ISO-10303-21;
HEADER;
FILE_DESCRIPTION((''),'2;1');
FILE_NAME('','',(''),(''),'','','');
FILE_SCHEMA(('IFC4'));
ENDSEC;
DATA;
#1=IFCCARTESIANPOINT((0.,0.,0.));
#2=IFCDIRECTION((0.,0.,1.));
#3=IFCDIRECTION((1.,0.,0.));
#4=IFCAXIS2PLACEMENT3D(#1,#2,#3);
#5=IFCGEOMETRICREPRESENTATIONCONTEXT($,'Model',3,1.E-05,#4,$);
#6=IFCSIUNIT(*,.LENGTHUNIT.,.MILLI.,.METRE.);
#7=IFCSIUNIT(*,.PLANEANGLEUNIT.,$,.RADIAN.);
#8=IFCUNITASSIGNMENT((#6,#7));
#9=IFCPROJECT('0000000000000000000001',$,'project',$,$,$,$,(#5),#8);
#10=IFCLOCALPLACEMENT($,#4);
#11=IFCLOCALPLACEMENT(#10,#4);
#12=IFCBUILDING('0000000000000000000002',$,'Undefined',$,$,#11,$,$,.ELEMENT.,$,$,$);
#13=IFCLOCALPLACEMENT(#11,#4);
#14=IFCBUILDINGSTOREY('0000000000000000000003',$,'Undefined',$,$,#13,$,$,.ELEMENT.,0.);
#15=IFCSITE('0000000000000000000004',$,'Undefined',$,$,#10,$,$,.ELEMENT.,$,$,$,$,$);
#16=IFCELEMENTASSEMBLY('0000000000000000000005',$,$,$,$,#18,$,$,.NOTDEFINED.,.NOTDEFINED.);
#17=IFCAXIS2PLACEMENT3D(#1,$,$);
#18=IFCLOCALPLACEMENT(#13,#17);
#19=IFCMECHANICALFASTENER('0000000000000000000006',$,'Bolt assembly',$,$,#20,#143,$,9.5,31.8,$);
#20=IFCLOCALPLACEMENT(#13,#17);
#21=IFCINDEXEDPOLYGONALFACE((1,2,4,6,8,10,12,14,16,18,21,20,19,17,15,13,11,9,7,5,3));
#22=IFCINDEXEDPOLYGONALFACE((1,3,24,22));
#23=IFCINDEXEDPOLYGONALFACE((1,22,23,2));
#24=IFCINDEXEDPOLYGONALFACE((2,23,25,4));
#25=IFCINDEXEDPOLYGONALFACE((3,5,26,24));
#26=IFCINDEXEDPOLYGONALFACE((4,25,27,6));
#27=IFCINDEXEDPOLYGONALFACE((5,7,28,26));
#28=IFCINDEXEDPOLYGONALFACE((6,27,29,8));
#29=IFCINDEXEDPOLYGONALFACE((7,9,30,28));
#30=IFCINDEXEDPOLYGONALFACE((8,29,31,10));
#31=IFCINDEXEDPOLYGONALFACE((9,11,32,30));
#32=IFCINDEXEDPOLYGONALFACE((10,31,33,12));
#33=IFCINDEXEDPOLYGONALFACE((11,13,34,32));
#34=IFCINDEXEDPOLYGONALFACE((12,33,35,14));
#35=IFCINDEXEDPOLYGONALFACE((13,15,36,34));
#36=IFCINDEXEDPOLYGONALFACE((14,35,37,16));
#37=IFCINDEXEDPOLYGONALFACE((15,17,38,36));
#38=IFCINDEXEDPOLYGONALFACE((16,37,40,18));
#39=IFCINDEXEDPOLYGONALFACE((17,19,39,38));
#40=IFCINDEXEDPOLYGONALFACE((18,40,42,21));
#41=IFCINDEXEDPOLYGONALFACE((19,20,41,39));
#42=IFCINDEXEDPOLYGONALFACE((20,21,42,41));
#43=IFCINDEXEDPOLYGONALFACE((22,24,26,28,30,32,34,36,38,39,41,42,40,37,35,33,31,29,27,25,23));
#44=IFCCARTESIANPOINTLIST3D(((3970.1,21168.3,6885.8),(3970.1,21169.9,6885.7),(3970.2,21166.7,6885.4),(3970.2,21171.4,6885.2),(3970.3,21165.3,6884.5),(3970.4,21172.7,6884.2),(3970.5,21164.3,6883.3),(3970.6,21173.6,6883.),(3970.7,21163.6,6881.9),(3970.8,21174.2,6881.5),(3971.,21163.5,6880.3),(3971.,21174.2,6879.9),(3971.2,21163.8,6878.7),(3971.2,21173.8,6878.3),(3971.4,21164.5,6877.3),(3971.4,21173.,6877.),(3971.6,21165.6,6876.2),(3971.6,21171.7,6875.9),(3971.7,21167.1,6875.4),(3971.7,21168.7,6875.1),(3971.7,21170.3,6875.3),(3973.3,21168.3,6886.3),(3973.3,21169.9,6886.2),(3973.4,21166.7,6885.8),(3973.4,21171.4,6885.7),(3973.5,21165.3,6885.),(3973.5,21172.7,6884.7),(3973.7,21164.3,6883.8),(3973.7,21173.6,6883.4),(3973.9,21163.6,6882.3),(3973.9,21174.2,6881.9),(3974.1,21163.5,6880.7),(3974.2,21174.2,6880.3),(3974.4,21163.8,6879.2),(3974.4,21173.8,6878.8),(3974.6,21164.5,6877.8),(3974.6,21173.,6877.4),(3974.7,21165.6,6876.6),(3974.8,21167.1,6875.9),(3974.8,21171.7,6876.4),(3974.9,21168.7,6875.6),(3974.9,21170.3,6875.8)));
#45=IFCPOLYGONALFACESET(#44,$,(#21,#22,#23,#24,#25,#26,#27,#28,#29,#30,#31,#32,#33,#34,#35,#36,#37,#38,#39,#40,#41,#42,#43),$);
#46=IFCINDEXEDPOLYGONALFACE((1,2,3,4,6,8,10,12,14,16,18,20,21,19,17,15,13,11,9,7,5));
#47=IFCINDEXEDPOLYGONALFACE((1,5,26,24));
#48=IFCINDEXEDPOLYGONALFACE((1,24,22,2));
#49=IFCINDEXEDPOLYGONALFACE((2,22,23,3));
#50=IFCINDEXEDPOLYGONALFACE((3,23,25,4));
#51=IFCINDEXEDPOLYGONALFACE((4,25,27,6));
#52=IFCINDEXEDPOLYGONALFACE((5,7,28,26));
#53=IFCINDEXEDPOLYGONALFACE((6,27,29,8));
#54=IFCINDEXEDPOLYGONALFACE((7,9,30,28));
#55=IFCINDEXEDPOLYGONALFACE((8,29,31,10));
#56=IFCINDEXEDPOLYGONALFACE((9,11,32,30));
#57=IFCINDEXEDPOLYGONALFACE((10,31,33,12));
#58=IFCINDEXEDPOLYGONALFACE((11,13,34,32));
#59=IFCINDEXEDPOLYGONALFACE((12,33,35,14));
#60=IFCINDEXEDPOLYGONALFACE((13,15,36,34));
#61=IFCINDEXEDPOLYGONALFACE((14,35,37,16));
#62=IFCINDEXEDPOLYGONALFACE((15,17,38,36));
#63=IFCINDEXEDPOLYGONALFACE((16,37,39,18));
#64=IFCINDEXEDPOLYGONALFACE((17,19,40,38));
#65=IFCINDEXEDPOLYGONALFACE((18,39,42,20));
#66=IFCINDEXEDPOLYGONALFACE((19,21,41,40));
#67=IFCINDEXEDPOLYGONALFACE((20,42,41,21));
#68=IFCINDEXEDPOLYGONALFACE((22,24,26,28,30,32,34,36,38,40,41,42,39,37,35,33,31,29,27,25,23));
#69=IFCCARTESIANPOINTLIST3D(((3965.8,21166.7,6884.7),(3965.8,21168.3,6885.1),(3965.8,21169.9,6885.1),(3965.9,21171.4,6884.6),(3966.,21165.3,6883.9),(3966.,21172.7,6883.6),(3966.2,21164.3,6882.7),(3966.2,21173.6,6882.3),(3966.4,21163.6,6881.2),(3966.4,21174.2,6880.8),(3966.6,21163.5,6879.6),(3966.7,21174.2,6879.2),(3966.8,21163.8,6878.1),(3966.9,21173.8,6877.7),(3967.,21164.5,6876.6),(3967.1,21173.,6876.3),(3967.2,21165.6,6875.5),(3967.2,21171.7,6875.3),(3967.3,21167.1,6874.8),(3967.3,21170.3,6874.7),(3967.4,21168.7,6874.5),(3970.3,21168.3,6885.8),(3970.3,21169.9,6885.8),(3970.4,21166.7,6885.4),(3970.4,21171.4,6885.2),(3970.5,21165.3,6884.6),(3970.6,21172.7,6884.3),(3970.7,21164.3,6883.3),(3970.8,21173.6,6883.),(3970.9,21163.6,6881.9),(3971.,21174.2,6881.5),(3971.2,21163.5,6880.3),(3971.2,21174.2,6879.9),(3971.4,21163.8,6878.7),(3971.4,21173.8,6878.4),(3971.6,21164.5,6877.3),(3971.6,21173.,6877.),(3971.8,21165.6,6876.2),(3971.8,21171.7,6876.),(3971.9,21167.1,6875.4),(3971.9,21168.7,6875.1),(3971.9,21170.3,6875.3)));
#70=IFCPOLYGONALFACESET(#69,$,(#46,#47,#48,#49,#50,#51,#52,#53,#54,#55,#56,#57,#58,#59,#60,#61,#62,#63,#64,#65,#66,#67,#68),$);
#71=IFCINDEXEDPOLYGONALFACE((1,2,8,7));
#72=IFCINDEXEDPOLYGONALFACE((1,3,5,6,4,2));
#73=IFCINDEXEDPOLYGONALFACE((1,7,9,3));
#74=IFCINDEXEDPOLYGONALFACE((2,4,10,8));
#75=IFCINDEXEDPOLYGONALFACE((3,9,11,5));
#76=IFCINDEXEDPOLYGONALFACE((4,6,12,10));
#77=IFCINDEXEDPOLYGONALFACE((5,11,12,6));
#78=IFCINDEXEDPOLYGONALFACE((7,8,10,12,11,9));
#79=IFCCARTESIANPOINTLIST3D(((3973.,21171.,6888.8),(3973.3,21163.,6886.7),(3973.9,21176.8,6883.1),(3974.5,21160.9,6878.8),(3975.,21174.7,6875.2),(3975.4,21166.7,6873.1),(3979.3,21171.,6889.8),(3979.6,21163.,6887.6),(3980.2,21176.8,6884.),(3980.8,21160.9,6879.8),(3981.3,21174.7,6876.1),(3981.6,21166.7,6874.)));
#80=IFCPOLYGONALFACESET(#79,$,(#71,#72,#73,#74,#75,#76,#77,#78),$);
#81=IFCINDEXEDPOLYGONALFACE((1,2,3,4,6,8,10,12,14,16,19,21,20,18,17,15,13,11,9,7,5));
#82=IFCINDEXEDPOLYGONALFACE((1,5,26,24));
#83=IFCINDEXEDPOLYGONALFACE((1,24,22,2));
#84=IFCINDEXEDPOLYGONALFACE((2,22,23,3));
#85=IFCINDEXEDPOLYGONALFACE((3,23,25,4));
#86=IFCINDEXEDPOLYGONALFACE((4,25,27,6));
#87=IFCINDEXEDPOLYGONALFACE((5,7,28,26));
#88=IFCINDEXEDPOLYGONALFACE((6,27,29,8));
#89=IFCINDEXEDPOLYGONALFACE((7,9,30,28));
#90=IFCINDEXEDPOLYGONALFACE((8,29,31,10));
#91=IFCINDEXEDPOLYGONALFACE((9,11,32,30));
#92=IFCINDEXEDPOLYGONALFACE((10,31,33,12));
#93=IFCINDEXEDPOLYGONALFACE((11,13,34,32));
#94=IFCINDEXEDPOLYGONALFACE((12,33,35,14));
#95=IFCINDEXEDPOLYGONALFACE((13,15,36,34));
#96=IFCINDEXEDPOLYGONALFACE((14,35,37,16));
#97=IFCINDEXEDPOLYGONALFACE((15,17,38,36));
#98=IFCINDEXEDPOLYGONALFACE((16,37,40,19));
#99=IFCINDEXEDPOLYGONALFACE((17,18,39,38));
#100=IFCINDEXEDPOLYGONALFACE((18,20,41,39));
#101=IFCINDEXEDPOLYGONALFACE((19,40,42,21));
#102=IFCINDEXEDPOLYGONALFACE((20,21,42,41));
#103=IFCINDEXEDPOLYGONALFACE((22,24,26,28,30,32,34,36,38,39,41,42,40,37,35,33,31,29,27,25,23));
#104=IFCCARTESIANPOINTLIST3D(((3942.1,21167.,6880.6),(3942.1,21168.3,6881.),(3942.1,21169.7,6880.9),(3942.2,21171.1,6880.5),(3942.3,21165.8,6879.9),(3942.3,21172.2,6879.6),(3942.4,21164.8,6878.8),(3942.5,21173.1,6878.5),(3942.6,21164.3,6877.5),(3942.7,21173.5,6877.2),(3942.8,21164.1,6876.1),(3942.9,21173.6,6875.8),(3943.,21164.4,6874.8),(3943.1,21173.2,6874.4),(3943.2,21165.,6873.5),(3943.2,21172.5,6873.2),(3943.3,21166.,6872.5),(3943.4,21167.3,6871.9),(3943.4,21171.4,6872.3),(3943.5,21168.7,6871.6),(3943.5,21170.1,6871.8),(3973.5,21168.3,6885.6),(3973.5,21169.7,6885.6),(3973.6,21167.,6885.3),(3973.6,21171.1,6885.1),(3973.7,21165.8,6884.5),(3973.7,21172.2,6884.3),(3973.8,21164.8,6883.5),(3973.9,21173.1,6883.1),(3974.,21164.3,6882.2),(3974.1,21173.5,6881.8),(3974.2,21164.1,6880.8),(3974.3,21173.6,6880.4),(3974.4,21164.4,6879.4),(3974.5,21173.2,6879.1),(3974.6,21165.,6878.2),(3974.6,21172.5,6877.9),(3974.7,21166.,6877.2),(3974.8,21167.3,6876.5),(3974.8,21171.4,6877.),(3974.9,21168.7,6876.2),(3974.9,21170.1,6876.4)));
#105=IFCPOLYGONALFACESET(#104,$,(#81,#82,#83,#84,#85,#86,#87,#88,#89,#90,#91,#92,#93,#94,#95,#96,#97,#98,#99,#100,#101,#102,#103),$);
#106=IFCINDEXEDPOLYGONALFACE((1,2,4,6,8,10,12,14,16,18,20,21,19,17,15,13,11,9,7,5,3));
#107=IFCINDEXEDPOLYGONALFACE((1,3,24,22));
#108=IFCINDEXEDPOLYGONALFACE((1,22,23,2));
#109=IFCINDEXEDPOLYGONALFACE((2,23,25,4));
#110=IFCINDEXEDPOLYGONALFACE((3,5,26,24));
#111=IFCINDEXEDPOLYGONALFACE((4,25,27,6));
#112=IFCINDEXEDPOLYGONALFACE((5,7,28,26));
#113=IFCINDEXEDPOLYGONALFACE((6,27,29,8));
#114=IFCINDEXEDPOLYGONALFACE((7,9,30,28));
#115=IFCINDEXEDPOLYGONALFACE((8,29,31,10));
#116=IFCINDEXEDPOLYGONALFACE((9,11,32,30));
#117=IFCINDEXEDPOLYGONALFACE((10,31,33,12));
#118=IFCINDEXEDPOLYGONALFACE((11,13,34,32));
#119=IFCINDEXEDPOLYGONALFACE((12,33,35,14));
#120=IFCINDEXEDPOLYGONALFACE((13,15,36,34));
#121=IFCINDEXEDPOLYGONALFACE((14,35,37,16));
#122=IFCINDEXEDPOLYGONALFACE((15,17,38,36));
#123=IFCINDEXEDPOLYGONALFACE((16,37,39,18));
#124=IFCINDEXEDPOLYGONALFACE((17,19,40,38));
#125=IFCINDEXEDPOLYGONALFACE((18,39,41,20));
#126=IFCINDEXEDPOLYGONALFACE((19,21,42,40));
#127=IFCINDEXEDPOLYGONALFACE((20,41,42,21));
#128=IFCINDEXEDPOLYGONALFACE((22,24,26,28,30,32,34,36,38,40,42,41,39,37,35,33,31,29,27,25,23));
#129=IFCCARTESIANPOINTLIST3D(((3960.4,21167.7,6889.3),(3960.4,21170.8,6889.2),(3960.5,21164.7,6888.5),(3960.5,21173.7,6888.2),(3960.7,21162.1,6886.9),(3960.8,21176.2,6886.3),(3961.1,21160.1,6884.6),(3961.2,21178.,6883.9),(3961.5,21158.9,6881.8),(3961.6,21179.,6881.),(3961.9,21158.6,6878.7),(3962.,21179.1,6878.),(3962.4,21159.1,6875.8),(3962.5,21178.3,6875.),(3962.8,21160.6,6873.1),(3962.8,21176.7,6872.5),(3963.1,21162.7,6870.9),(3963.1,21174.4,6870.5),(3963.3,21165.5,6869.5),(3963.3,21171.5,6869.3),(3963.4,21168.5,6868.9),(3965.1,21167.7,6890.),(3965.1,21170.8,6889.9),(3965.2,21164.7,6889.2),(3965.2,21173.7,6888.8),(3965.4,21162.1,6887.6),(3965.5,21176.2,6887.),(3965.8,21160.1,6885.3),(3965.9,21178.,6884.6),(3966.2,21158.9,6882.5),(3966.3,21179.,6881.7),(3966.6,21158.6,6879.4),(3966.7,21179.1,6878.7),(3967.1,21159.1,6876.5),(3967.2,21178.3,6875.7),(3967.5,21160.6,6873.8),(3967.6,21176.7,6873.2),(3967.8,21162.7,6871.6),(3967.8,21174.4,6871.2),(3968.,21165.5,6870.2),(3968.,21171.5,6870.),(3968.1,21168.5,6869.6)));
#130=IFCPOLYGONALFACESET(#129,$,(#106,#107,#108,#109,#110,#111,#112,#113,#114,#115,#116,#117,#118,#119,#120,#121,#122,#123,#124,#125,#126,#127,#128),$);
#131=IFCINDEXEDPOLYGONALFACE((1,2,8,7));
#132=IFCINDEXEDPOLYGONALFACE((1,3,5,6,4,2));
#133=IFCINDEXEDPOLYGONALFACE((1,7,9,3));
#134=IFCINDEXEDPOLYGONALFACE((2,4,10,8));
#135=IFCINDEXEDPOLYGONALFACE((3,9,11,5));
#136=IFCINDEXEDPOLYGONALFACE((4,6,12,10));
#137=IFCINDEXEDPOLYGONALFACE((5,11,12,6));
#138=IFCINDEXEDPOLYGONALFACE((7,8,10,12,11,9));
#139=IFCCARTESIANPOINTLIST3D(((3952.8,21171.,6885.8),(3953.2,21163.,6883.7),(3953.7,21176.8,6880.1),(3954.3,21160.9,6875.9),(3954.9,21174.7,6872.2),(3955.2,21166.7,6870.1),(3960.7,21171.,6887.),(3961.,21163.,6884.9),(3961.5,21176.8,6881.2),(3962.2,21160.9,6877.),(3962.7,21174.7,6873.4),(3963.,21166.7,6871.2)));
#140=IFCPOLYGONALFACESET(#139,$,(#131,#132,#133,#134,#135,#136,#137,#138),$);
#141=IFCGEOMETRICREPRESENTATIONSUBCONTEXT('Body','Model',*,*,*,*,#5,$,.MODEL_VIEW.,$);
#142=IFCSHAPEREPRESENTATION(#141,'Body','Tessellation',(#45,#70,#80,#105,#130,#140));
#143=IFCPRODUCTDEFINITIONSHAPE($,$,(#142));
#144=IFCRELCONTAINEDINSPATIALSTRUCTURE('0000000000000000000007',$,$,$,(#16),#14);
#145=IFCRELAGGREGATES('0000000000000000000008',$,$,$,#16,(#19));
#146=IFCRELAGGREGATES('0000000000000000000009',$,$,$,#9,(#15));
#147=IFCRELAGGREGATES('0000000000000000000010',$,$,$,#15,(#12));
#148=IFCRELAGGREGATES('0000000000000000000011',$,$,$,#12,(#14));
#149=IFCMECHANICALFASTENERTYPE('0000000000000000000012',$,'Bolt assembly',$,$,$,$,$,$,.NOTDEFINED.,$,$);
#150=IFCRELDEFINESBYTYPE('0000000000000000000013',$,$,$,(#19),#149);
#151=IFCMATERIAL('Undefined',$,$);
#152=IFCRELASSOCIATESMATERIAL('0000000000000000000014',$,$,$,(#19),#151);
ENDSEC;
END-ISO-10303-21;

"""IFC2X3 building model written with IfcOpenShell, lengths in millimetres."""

from ifc_helpers import new_model, si_unit, frame, origin_with_axes, origin_2d_with_axis, place, context, subcontext, project, spatial, polyline, circle, outline, extrude, source, transform, mapped, material, type_object, element, aggregate, save


model = new_model("IFC2X3")

# Units and contexts
model_context = context("Model", 3, precision=1e-05, world=origin_with_axes())
body_context = subcontext(model_context, "Body", "Model", "MODEL_VIEW")
ifc_project = project(units=[si_unit("LENGTHUNIT", "METRE", prefix="MILLI"), si_unit("PLANEANGLEUNIT", "RADIAN")], contexts=[model_context])

# Site, building, storey
site_placement = place(None, origin_with_axes())
site = spatial("IfcSite", under=ifc_project, at=site_placement, Name="Undefined", CompositionType="ELEMENT")
building_placement = place(site_placement, origin_with_axes())
building = spatial("IfcBuilding", under=site, at=building_placement, Name="Undefined", CompositionType="ELEMENT")
storey_placement = place(building_placement, origin_with_axes())
storey = spatial("IfcBuildingStorey", under=building, at=storey_placement, Name="Undefined", CompositionType="ELEMENT", Elevation=0.0)

# Element assembly
assembly_1_placement = place(storey_placement, origin_with_axes())
assembly_1 = element("IfcElementAssembly", 1, at=assembly_1_placement, inside=storey, AssemblyPlace="NOTDEFINED", PredefinedType="NOTDEFINED")

# Shared definitions
ifc_material_1 = material(Name="Undefined")
mechanical_fastener_type = type_object("IfcMechanicalFastenerType", Name="Bolt assembly")

# Mechanical fastener
shared_shape_1 = source(origin_with_axes(), body_context, "Body", "SweptSolid", [
    extrude(circle(Radius=5.4, at=origin_2d_with_axis()), frame((0.0, -3.1, 0.0), z_axis=(0.0, 1.0, 0.0), x_axis=(1.0, 0.0, 0.0)), (0.0, 0.0, 1.0), 3.2),
    extrude(circle(Radius=5.4, at=origin_2d_with_axis()), frame((0.0, -0.1, 0.0), z_axis=(0.0, 1.0, 0.0), x_axis=(1.0, 0.0, 0.0)), (0.0, 0.0, 1.0), 4.6),
    extrude(outline(polyline([(7.1, -4.1), (7.1, 4.1), (0.0, 8.2), (-7.1, 4.1), (-7.1, -4.1), (0.0, -8.2), (7.1, -4.1)])), frame((0.0, -9.6, 0.0), z_axis=(0.0, 1.0, 0.0), x_axis=(1.0, 0.0, 0.0)), (0.0, 0.0, 1.0), 6.3),
    extrude(circle(Radius=4.8, at=origin_2d_with_axis()), frame((0.0, -3.2, 0.0), z_axis=(0.0, 1.0, 0.0), x_axis=(1.0, 0.0, 0.0)), (0.0, 0.0, 1.0), 31.8),
    extrude(circle(Radius=10.3, at=origin_2d_with_axis()), frame((0.0, 4.5, 0.0), z_axis=(0.0, 1.0, 0.0), x_axis=(1.0, 0.0, 0.0)), (0.0, 0.0, 1.0), 4.8),
    extrude(outline(polyline([(7.1, -4.1), (7.1, 4.1), (0.0, 8.2), (-7.1, 4.1), (-7.1, -4.1), (0.0, -8.2), (7.1, -4.1)])), frame((0.0, 9.3, 0.0), z_axis=(0.0, 1.0, 0.0), x_axis=(1.0, 0.0, 0.0)), (0.0, 0.0, 1.0), 7.9),
])
mechanical_fastener_1_placement = place(assembly_1_placement, frame((3971.0, 21168.9, 6880.5), z_axis=(-0.103381, -0.707107, 0.699509), x_axis=(-0.103381, 0.707107, 0.699509)))
mechanical_fastener_1 = element("IfcMechanicalFastener", 2, at=mechanical_fastener_1_placement, type_object=mechanical_fastener_type, material=ifc_material_1, Name="Bolt assembly", NominalDiameter=9.5, NominalLength=31.8, context=body_context, shape_type="MappedRepresentation", body=[
    mapped(shared_shape_1, transform((0.0, 0.0, 0.0))),
])
aggregate(assembly_1, [mechanical_fastener_1])

save(model, "model.ifc")
